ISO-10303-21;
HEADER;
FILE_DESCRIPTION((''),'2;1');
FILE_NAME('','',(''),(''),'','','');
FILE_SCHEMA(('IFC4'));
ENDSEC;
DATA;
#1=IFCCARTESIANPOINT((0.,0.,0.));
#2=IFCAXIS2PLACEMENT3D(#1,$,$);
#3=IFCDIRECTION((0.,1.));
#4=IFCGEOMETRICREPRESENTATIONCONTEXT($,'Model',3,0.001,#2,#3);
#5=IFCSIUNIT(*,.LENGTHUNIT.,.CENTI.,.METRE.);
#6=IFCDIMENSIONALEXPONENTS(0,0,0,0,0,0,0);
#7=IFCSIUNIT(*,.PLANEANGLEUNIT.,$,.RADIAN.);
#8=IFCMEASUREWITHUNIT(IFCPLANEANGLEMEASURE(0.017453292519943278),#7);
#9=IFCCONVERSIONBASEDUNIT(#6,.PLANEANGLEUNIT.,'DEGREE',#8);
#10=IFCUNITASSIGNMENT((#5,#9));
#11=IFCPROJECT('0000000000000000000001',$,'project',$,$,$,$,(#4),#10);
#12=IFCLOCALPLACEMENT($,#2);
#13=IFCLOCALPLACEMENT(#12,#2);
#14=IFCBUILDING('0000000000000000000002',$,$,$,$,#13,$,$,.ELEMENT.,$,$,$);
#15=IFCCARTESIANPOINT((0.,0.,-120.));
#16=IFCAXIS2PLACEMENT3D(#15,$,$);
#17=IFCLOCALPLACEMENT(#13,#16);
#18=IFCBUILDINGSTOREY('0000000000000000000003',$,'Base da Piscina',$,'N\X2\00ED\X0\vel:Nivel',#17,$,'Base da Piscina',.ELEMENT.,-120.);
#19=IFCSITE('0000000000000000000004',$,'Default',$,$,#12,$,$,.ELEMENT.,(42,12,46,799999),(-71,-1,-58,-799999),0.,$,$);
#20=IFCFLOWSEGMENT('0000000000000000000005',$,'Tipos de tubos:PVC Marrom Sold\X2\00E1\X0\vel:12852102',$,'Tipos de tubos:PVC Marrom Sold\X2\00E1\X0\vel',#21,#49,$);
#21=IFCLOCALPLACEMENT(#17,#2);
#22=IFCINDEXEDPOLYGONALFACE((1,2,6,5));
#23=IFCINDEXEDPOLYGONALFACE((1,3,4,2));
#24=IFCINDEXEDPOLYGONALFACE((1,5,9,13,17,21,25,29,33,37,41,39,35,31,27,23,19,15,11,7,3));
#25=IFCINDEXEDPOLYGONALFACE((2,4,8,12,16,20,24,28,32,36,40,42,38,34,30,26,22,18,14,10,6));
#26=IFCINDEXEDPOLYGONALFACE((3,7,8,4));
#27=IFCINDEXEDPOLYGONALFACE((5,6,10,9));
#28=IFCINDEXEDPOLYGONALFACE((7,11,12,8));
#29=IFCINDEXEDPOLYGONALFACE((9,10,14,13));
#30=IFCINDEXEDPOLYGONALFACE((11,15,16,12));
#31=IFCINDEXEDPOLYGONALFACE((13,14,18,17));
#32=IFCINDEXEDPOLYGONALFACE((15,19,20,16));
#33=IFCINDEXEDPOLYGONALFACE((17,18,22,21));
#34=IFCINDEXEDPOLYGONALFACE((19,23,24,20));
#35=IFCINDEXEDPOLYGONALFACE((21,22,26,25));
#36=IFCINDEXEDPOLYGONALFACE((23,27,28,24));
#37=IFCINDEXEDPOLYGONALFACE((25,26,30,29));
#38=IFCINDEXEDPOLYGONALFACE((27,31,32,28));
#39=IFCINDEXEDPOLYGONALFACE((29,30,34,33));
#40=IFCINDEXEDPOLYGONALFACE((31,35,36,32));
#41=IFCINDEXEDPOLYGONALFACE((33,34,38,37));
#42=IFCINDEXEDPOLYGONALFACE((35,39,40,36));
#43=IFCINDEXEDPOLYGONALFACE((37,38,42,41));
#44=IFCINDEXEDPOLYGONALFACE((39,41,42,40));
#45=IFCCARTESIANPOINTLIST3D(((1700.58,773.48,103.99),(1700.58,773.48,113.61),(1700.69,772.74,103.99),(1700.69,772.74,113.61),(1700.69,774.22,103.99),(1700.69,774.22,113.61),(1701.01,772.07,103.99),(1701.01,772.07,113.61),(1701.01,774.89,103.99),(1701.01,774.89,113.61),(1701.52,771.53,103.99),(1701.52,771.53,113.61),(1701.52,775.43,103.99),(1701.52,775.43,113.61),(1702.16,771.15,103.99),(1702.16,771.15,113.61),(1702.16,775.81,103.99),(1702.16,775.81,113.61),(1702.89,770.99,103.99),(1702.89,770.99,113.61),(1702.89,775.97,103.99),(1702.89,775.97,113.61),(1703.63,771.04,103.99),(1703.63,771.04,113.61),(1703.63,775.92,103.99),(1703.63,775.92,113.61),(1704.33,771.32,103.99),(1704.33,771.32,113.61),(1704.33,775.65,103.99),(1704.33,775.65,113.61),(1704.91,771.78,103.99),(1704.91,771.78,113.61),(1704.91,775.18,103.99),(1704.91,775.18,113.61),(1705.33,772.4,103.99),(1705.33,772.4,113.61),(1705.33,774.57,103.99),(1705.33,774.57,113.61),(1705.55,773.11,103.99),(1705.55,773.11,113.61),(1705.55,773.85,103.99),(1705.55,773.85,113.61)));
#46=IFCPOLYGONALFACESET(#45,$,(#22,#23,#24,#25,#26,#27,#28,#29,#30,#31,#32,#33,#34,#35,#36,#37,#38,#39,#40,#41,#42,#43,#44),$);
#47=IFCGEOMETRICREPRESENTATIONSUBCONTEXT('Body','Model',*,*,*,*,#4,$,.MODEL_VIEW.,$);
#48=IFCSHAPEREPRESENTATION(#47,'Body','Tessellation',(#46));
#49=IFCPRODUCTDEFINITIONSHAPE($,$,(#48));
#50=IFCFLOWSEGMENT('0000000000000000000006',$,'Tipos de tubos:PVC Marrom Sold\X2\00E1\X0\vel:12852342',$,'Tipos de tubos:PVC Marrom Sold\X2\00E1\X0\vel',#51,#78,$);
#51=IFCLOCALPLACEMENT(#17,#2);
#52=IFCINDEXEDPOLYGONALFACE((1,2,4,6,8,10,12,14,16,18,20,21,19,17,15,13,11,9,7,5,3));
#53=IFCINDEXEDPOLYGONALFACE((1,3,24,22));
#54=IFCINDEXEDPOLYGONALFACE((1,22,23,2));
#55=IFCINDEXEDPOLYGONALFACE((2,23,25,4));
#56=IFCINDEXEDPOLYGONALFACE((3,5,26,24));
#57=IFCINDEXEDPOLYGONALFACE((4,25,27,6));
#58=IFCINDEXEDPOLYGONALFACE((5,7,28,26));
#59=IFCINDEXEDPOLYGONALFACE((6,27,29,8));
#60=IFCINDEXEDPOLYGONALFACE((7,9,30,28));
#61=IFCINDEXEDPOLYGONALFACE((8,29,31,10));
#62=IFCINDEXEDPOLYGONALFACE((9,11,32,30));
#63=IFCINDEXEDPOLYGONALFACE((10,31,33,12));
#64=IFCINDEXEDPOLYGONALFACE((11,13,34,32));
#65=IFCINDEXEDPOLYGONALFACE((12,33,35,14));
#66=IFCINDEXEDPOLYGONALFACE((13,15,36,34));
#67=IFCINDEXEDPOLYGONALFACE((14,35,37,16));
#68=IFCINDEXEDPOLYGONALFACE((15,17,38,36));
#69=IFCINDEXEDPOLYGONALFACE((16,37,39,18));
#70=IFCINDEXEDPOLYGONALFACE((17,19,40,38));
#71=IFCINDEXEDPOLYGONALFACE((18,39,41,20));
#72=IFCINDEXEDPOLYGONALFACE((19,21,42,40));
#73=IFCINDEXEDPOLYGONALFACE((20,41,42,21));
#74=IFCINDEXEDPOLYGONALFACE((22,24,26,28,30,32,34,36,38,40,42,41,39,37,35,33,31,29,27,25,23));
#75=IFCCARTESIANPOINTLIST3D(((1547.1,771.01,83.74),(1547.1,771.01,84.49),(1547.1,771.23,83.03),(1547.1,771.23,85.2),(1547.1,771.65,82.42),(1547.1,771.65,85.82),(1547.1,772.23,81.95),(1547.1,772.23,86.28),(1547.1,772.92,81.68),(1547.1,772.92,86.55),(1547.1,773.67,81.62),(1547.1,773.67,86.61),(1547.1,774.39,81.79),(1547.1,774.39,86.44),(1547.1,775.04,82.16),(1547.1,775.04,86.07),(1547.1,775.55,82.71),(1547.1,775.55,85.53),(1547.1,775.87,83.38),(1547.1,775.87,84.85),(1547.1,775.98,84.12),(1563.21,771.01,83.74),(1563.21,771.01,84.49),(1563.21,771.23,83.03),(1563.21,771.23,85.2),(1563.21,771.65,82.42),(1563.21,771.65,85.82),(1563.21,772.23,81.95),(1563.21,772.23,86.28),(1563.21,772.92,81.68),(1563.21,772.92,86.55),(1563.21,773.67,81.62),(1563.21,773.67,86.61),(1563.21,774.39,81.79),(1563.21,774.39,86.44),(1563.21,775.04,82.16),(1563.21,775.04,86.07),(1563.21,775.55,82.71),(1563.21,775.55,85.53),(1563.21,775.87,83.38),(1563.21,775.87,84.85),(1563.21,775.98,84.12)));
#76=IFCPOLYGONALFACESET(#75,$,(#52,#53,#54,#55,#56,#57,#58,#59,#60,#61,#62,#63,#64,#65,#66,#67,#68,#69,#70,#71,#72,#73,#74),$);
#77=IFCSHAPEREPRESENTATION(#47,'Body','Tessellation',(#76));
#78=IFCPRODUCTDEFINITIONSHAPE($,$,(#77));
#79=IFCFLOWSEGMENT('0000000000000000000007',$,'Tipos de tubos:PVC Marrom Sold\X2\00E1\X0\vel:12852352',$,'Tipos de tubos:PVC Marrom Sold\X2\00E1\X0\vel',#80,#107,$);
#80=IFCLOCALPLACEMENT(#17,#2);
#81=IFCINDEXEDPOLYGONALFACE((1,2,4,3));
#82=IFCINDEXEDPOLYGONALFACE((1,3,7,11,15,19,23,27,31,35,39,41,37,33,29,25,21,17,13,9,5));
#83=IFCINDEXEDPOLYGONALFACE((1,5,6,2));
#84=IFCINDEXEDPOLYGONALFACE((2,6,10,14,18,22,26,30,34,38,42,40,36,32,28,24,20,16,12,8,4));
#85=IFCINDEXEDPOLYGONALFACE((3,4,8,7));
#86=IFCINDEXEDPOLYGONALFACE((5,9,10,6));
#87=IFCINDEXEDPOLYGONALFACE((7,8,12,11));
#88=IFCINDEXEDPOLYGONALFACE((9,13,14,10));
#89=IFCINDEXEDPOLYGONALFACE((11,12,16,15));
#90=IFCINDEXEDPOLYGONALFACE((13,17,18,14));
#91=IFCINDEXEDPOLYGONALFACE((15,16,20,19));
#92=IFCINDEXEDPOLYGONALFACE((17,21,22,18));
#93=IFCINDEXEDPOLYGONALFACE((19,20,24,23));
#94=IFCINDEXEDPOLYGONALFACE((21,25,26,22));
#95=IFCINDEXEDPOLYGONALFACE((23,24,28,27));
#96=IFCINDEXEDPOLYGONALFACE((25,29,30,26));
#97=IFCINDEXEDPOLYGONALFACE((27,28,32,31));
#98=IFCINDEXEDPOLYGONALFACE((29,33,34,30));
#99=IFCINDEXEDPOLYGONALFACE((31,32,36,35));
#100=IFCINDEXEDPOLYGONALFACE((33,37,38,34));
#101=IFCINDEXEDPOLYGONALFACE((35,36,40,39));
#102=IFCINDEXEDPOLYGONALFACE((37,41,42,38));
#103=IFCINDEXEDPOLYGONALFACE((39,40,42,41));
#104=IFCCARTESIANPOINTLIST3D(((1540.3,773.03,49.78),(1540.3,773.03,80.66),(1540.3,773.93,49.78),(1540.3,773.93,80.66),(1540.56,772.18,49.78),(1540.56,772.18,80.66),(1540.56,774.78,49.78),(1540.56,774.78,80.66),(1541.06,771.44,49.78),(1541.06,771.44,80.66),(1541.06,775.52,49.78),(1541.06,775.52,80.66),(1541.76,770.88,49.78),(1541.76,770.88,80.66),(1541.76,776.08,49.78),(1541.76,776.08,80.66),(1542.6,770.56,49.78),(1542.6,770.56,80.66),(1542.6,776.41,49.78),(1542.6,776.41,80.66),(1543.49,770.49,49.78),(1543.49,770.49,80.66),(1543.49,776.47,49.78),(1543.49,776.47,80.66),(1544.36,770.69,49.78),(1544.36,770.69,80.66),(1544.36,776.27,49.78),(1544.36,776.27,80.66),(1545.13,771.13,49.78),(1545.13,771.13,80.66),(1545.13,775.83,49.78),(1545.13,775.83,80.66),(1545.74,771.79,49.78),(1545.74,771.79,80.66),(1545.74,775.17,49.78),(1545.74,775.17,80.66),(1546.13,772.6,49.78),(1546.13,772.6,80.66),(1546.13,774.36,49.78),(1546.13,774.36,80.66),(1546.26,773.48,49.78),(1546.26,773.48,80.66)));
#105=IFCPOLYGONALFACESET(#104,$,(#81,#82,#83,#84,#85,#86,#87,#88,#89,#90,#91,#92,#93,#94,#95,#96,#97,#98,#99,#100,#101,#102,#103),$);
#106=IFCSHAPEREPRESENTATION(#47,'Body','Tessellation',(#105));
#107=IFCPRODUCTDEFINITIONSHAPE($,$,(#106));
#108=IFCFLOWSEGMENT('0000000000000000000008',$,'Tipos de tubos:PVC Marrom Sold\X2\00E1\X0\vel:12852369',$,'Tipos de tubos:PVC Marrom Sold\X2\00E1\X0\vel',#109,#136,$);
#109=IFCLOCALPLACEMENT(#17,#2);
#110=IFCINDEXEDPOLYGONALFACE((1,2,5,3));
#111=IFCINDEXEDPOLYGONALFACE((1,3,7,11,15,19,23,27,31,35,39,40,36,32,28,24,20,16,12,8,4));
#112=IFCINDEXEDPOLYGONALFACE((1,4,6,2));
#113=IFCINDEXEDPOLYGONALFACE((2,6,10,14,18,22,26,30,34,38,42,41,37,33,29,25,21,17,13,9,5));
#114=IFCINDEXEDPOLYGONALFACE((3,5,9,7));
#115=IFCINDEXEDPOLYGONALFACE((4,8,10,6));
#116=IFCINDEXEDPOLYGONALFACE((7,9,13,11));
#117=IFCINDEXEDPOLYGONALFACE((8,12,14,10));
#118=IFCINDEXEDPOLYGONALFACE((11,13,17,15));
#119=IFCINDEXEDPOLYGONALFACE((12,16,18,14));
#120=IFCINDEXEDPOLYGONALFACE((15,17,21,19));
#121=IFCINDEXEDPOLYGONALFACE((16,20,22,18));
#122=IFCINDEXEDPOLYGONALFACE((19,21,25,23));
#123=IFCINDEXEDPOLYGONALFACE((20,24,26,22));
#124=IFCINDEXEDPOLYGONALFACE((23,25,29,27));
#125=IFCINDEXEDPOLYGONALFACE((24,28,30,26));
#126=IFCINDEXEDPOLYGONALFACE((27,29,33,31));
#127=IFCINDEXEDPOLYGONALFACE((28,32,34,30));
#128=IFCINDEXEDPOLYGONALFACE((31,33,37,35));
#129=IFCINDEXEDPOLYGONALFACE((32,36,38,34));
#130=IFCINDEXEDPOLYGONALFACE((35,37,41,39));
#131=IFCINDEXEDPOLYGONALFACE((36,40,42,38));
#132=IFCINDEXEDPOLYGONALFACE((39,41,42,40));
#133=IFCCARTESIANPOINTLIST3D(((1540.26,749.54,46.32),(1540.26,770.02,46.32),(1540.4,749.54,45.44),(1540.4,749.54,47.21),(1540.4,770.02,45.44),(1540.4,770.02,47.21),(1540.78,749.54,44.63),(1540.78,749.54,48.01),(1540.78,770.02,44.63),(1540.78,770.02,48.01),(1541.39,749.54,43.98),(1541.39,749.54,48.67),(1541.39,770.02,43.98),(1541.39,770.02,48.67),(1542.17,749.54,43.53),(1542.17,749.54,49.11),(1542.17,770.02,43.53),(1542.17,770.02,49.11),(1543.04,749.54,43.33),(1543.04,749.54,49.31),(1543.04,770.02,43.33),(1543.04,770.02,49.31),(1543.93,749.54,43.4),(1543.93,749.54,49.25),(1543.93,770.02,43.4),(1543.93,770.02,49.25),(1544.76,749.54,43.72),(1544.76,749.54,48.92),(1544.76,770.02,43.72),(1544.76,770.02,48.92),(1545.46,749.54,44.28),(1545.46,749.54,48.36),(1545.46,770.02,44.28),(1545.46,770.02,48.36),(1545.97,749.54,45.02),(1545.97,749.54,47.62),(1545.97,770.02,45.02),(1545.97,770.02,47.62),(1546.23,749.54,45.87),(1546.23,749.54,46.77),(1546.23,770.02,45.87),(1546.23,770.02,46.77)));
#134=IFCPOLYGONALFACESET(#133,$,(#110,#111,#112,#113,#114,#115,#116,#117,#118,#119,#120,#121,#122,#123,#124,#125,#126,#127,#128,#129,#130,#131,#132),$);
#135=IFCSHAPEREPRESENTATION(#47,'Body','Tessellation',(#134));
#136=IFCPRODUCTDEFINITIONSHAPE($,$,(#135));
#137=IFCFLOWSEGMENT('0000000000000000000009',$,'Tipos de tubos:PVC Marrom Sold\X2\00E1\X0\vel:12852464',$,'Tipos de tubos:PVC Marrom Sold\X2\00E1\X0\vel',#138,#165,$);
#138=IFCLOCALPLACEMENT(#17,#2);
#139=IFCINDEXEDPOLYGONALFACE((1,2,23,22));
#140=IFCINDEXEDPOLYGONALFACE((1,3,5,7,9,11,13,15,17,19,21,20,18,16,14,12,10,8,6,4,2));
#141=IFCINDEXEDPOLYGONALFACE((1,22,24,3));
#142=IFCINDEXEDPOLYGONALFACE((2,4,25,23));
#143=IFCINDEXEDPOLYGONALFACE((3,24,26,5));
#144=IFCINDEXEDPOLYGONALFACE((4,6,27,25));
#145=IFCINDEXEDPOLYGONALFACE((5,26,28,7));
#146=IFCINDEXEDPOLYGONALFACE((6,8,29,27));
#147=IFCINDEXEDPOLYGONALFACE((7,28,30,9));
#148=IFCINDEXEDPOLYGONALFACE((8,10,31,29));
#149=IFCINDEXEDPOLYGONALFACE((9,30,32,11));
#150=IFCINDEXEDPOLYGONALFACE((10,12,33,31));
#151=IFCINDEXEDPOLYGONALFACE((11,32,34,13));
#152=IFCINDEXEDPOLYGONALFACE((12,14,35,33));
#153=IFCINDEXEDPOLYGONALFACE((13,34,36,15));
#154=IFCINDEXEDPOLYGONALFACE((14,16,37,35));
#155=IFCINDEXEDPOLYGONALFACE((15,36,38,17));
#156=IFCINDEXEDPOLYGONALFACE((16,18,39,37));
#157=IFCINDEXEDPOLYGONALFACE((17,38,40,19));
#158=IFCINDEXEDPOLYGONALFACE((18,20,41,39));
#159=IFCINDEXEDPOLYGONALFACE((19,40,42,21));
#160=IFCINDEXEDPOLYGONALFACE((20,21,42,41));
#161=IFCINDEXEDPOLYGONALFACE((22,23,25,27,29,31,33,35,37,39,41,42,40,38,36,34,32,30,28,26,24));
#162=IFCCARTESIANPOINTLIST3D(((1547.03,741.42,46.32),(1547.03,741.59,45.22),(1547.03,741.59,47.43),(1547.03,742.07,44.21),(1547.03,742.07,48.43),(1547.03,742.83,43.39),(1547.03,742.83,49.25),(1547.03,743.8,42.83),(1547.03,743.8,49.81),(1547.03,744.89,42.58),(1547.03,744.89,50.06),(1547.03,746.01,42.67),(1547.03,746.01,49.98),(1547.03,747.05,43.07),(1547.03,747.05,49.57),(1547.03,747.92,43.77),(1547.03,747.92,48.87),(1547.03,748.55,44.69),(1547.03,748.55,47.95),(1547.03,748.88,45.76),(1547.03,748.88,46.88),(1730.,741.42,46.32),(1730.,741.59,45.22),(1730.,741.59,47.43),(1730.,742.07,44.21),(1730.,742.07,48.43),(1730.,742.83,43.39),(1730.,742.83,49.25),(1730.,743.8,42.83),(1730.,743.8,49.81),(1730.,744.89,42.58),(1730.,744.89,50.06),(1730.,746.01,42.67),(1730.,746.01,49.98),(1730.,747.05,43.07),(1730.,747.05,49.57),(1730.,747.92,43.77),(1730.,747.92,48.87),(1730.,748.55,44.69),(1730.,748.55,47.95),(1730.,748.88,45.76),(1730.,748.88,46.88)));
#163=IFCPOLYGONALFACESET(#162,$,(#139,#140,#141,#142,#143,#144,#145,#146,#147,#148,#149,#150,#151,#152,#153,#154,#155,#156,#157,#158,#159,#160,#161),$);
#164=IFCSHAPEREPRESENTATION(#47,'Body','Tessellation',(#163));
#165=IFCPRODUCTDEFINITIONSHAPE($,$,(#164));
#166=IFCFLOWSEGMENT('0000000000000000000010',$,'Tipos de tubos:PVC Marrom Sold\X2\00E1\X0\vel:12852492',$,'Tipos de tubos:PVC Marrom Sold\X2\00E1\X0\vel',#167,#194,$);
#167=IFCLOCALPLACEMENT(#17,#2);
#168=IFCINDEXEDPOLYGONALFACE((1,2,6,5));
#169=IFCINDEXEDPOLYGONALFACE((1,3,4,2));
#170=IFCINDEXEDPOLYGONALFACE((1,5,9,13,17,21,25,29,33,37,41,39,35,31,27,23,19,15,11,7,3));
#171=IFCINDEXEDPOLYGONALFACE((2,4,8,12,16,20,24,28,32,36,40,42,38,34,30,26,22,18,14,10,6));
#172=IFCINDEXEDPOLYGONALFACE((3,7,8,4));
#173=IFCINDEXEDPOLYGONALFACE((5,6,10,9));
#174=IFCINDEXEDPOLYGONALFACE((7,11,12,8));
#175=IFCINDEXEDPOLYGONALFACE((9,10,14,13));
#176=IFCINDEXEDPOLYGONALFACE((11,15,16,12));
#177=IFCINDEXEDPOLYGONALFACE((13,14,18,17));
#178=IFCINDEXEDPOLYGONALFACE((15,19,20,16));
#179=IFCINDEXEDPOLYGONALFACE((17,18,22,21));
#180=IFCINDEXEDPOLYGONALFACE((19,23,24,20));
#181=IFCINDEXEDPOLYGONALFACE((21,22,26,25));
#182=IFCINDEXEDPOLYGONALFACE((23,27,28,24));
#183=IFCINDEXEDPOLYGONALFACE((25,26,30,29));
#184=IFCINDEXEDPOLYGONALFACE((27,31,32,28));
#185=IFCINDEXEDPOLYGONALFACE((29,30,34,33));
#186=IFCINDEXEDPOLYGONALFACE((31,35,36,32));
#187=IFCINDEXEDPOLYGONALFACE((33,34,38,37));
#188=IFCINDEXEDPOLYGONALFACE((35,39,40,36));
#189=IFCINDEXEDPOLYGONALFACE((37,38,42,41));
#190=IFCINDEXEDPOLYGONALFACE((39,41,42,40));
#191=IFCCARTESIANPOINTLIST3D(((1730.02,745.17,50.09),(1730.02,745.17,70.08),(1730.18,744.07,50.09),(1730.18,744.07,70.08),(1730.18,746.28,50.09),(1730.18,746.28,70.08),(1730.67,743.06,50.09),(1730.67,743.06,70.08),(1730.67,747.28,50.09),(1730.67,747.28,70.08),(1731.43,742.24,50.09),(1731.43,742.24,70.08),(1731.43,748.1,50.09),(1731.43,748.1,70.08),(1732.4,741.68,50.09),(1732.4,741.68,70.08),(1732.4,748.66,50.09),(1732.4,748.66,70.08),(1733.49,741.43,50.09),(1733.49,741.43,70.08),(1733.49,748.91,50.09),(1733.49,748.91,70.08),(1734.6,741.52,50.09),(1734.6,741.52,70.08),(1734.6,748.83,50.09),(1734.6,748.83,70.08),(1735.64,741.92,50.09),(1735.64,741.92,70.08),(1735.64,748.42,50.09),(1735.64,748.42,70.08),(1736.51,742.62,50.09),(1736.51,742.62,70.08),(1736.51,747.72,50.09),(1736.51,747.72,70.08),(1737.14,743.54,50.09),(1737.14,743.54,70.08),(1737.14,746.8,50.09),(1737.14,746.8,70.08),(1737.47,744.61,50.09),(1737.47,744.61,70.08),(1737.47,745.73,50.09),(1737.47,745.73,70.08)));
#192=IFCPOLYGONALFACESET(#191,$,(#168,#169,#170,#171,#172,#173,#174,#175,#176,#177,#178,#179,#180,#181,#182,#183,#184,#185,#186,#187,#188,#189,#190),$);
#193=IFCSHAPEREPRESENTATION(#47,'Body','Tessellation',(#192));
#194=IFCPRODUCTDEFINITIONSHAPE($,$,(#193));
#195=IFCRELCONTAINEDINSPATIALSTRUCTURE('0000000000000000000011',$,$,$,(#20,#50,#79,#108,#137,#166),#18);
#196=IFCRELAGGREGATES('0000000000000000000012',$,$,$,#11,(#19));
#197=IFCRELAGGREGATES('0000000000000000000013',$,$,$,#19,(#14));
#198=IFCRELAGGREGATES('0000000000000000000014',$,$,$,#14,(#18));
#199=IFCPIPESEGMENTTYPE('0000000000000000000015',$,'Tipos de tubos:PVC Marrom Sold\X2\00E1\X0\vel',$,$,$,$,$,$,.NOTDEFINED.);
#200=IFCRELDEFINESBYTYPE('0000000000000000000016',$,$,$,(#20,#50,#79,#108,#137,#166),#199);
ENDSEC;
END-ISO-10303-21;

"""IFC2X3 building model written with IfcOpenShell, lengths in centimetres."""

from ifc_helpers import new_model, entity, si_unit, converted_unit, direction, frame, frame_2d, origin, origin_2d_with_axis, place, context, subcontext, project, spatial, circle, extrude, type_object, element, save


model = new_model("IFC2X3")

# Units and contexts
model_context = context("Model", 3, precision=0.001, world=origin(), true_north=direction((0.0, 1.0)))
body_context = subcontext(model_context, "Body", "Model", "MODEL_VIEW")
ifc_project = project(units=[si_unit("LENGTHUNIT", "METRE", prefix="CENTI"), converted_unit("PLANEANGLEUNIT", "DEGREE", entity("IfcPlaneAngleMeasure", 0.017453292519943278), si_unit("PLANEANGLEUNIT", "RADIAN"), dimensions=[0, 0, 0, 0, 0, 0, 0])], contexts=[model_context])

# Site, building, storey
site_placement = place(None, origin())
site = spatial("IfcSite", under=ifc_project, at=site_placement, Name="Default", CompositionType="ELEMENT", RefLatitude=(42, 12, 46, 799999), RefLongitude=(-71, -1, -58, -799999), RefElevation=0.0)
building_placement = place(site_placement, origin())
building = spatial("IfcBuilding", under=site, at=building_placement, CompositionType="ELEMENT")
storey_placement = place(building_placement, frame((0.0, 0.0, -120.0)))
storey = spatial("IfcBuildingStorey", under=building, at=storey_placement, Name="Base da Piscina", ObjectType="Nível:Nivel", LongName="Base da Piscina", CompositionType="ELEMENT", Elevation=-120.0)

# Flow segments
pipe_segment_type = type_object("IfcPipeSegmentType", Name="Tipos de tubos:PVC Marrom Soldável", PredefinedType="NOTDEFINED")
flow_segment_1_placement = place(storey_placement, origin())
element("IfcFlowSegment", 1, at=flow_segment_1_placement, inside=storey, type_object=pipe_segment_type, Name="Tipos de tubos:PVC Marrom Soldável:12852102", ObjectType="Tipos de tubos:PVC Marrom Soldável", context=body_context, shape_type="SweptSolid", body=[
    extrude(circle(Radius=2.5, at=origin_2d_with_axis()), frame((1703.08, 773.48, 103.99), z_axis=(0.0, 0.0, 1.0), x_axis=(-1.0, 0.0, 0.0)), (0.0, 0.0, 1.0), 9.62),
])
flow_segment_2_placement = place(storey_placement, origin())
element("IfcFlowSegment", 2, at=flow_segment_2_placement, inside=storey, type_object=pipe_segment_type, Name="Tipos de tubos:PVC Marrom Soldável:12852342", ObjectType="Tipos de tubos:PVC Marrom Soldável", context=body_context, shape_type="SweptSolid", body=[
    extrude(circle(Radius=2.5, at=origin_2d_with_axis()), frame((1547.1, 773.48, 84.12), z_axis=(1.0, 0.0, 0.0), x_axis=(0.0, 1.0, 0.0)), (0.0, 0.0, 1.0), 16.11),
])
flow_segment_3_placement = place(storey_placement, origin())
element("IfcFlowSegment", 3, at=flow_segment_3_placement, inside=storey, type_object=pipe_segment_type, Name="Tipos de tubos:PVC Marrom Soldável:12852352", ObjectType="Tipos de tubos:PVC Marrom Soldável", context=body_context, shape_type="SweptSolid", body=[
    extrude(circle(Radius=3.0, at=origin_2d_with_axis()), frame((1543.26, 773.48, 49.78)), (0.0, 0.0, 1.0), 30.88),
])
flow_segment_4_placement = place(storey_placement, origin())
element("IfcFlowSegment", 4, at=flow_segment_4_placement, inside=storey, type_object=pipe_segment_type, Name="Tipos de tubos:PVC Marrom Soldável:12852369", ObjectType="Tipos de tubos:PVC Marrom Soldável", context=body_context, shape_type="SweptSolid", body=[
    extrude(circle(Radius=3.0, at=origin_2d_with_axis()), frame((1543.26, 749.54, 46.32), z_axis=(0.0, 1.0, 0.0), x_axis=(-1.0, 0.0, 0.0)), (0.0, 0.0, 1.0), 20.48),
])
flow_segment_5_placement = place(storey_placement, origin())
element("IfcFlowSegment", 5, at=flow_segment_5_placement, inside=storey, type_object=pipe_segment_type, Name="Tipos de tubos:PVC Marrom Soldável:12852464", ObjectType="Tipos de tubos:PVC Marrom Soldável", context=body_context, shape_type="SweptSolid", body=[
    extrude(circle(Radius=3.75, at=frame_2d((0.0, 0.0), x_axis=(1.0, 0.0))), frame((1547.03, 745.17, 46.32), z_axis=(1.0, 0.0, 0.0), x_axis=(0.0, -1.0, 0.0)), (0.0, 0.0, 1.0), 182.96),
])
flow_segment_6_placement = place(storey_placement, origin())
element("IfcFlowSegment", 6, at=flow_segment_6_placement, inside=storey, type_object=pipe_segment_type, Name="Tipos de tubos:PVC Marrom Soldável:12852492", ObjectType="Tipos de tubos:PVC Marrom Soldável", context=body_context, shape_type="SweptSolid", body=[
    extrude(circle(Radius=3.75, at=origin_2d_with_axis()), frame((1733.77, 745.17, 50.09), z_axis=(0.0, 0.0, 1.0), x_axis=(-1.0, 0.0, 0.0)), (0.0, 0.0, 1.0), 19.99),
])

save(model, "model.ifc")
